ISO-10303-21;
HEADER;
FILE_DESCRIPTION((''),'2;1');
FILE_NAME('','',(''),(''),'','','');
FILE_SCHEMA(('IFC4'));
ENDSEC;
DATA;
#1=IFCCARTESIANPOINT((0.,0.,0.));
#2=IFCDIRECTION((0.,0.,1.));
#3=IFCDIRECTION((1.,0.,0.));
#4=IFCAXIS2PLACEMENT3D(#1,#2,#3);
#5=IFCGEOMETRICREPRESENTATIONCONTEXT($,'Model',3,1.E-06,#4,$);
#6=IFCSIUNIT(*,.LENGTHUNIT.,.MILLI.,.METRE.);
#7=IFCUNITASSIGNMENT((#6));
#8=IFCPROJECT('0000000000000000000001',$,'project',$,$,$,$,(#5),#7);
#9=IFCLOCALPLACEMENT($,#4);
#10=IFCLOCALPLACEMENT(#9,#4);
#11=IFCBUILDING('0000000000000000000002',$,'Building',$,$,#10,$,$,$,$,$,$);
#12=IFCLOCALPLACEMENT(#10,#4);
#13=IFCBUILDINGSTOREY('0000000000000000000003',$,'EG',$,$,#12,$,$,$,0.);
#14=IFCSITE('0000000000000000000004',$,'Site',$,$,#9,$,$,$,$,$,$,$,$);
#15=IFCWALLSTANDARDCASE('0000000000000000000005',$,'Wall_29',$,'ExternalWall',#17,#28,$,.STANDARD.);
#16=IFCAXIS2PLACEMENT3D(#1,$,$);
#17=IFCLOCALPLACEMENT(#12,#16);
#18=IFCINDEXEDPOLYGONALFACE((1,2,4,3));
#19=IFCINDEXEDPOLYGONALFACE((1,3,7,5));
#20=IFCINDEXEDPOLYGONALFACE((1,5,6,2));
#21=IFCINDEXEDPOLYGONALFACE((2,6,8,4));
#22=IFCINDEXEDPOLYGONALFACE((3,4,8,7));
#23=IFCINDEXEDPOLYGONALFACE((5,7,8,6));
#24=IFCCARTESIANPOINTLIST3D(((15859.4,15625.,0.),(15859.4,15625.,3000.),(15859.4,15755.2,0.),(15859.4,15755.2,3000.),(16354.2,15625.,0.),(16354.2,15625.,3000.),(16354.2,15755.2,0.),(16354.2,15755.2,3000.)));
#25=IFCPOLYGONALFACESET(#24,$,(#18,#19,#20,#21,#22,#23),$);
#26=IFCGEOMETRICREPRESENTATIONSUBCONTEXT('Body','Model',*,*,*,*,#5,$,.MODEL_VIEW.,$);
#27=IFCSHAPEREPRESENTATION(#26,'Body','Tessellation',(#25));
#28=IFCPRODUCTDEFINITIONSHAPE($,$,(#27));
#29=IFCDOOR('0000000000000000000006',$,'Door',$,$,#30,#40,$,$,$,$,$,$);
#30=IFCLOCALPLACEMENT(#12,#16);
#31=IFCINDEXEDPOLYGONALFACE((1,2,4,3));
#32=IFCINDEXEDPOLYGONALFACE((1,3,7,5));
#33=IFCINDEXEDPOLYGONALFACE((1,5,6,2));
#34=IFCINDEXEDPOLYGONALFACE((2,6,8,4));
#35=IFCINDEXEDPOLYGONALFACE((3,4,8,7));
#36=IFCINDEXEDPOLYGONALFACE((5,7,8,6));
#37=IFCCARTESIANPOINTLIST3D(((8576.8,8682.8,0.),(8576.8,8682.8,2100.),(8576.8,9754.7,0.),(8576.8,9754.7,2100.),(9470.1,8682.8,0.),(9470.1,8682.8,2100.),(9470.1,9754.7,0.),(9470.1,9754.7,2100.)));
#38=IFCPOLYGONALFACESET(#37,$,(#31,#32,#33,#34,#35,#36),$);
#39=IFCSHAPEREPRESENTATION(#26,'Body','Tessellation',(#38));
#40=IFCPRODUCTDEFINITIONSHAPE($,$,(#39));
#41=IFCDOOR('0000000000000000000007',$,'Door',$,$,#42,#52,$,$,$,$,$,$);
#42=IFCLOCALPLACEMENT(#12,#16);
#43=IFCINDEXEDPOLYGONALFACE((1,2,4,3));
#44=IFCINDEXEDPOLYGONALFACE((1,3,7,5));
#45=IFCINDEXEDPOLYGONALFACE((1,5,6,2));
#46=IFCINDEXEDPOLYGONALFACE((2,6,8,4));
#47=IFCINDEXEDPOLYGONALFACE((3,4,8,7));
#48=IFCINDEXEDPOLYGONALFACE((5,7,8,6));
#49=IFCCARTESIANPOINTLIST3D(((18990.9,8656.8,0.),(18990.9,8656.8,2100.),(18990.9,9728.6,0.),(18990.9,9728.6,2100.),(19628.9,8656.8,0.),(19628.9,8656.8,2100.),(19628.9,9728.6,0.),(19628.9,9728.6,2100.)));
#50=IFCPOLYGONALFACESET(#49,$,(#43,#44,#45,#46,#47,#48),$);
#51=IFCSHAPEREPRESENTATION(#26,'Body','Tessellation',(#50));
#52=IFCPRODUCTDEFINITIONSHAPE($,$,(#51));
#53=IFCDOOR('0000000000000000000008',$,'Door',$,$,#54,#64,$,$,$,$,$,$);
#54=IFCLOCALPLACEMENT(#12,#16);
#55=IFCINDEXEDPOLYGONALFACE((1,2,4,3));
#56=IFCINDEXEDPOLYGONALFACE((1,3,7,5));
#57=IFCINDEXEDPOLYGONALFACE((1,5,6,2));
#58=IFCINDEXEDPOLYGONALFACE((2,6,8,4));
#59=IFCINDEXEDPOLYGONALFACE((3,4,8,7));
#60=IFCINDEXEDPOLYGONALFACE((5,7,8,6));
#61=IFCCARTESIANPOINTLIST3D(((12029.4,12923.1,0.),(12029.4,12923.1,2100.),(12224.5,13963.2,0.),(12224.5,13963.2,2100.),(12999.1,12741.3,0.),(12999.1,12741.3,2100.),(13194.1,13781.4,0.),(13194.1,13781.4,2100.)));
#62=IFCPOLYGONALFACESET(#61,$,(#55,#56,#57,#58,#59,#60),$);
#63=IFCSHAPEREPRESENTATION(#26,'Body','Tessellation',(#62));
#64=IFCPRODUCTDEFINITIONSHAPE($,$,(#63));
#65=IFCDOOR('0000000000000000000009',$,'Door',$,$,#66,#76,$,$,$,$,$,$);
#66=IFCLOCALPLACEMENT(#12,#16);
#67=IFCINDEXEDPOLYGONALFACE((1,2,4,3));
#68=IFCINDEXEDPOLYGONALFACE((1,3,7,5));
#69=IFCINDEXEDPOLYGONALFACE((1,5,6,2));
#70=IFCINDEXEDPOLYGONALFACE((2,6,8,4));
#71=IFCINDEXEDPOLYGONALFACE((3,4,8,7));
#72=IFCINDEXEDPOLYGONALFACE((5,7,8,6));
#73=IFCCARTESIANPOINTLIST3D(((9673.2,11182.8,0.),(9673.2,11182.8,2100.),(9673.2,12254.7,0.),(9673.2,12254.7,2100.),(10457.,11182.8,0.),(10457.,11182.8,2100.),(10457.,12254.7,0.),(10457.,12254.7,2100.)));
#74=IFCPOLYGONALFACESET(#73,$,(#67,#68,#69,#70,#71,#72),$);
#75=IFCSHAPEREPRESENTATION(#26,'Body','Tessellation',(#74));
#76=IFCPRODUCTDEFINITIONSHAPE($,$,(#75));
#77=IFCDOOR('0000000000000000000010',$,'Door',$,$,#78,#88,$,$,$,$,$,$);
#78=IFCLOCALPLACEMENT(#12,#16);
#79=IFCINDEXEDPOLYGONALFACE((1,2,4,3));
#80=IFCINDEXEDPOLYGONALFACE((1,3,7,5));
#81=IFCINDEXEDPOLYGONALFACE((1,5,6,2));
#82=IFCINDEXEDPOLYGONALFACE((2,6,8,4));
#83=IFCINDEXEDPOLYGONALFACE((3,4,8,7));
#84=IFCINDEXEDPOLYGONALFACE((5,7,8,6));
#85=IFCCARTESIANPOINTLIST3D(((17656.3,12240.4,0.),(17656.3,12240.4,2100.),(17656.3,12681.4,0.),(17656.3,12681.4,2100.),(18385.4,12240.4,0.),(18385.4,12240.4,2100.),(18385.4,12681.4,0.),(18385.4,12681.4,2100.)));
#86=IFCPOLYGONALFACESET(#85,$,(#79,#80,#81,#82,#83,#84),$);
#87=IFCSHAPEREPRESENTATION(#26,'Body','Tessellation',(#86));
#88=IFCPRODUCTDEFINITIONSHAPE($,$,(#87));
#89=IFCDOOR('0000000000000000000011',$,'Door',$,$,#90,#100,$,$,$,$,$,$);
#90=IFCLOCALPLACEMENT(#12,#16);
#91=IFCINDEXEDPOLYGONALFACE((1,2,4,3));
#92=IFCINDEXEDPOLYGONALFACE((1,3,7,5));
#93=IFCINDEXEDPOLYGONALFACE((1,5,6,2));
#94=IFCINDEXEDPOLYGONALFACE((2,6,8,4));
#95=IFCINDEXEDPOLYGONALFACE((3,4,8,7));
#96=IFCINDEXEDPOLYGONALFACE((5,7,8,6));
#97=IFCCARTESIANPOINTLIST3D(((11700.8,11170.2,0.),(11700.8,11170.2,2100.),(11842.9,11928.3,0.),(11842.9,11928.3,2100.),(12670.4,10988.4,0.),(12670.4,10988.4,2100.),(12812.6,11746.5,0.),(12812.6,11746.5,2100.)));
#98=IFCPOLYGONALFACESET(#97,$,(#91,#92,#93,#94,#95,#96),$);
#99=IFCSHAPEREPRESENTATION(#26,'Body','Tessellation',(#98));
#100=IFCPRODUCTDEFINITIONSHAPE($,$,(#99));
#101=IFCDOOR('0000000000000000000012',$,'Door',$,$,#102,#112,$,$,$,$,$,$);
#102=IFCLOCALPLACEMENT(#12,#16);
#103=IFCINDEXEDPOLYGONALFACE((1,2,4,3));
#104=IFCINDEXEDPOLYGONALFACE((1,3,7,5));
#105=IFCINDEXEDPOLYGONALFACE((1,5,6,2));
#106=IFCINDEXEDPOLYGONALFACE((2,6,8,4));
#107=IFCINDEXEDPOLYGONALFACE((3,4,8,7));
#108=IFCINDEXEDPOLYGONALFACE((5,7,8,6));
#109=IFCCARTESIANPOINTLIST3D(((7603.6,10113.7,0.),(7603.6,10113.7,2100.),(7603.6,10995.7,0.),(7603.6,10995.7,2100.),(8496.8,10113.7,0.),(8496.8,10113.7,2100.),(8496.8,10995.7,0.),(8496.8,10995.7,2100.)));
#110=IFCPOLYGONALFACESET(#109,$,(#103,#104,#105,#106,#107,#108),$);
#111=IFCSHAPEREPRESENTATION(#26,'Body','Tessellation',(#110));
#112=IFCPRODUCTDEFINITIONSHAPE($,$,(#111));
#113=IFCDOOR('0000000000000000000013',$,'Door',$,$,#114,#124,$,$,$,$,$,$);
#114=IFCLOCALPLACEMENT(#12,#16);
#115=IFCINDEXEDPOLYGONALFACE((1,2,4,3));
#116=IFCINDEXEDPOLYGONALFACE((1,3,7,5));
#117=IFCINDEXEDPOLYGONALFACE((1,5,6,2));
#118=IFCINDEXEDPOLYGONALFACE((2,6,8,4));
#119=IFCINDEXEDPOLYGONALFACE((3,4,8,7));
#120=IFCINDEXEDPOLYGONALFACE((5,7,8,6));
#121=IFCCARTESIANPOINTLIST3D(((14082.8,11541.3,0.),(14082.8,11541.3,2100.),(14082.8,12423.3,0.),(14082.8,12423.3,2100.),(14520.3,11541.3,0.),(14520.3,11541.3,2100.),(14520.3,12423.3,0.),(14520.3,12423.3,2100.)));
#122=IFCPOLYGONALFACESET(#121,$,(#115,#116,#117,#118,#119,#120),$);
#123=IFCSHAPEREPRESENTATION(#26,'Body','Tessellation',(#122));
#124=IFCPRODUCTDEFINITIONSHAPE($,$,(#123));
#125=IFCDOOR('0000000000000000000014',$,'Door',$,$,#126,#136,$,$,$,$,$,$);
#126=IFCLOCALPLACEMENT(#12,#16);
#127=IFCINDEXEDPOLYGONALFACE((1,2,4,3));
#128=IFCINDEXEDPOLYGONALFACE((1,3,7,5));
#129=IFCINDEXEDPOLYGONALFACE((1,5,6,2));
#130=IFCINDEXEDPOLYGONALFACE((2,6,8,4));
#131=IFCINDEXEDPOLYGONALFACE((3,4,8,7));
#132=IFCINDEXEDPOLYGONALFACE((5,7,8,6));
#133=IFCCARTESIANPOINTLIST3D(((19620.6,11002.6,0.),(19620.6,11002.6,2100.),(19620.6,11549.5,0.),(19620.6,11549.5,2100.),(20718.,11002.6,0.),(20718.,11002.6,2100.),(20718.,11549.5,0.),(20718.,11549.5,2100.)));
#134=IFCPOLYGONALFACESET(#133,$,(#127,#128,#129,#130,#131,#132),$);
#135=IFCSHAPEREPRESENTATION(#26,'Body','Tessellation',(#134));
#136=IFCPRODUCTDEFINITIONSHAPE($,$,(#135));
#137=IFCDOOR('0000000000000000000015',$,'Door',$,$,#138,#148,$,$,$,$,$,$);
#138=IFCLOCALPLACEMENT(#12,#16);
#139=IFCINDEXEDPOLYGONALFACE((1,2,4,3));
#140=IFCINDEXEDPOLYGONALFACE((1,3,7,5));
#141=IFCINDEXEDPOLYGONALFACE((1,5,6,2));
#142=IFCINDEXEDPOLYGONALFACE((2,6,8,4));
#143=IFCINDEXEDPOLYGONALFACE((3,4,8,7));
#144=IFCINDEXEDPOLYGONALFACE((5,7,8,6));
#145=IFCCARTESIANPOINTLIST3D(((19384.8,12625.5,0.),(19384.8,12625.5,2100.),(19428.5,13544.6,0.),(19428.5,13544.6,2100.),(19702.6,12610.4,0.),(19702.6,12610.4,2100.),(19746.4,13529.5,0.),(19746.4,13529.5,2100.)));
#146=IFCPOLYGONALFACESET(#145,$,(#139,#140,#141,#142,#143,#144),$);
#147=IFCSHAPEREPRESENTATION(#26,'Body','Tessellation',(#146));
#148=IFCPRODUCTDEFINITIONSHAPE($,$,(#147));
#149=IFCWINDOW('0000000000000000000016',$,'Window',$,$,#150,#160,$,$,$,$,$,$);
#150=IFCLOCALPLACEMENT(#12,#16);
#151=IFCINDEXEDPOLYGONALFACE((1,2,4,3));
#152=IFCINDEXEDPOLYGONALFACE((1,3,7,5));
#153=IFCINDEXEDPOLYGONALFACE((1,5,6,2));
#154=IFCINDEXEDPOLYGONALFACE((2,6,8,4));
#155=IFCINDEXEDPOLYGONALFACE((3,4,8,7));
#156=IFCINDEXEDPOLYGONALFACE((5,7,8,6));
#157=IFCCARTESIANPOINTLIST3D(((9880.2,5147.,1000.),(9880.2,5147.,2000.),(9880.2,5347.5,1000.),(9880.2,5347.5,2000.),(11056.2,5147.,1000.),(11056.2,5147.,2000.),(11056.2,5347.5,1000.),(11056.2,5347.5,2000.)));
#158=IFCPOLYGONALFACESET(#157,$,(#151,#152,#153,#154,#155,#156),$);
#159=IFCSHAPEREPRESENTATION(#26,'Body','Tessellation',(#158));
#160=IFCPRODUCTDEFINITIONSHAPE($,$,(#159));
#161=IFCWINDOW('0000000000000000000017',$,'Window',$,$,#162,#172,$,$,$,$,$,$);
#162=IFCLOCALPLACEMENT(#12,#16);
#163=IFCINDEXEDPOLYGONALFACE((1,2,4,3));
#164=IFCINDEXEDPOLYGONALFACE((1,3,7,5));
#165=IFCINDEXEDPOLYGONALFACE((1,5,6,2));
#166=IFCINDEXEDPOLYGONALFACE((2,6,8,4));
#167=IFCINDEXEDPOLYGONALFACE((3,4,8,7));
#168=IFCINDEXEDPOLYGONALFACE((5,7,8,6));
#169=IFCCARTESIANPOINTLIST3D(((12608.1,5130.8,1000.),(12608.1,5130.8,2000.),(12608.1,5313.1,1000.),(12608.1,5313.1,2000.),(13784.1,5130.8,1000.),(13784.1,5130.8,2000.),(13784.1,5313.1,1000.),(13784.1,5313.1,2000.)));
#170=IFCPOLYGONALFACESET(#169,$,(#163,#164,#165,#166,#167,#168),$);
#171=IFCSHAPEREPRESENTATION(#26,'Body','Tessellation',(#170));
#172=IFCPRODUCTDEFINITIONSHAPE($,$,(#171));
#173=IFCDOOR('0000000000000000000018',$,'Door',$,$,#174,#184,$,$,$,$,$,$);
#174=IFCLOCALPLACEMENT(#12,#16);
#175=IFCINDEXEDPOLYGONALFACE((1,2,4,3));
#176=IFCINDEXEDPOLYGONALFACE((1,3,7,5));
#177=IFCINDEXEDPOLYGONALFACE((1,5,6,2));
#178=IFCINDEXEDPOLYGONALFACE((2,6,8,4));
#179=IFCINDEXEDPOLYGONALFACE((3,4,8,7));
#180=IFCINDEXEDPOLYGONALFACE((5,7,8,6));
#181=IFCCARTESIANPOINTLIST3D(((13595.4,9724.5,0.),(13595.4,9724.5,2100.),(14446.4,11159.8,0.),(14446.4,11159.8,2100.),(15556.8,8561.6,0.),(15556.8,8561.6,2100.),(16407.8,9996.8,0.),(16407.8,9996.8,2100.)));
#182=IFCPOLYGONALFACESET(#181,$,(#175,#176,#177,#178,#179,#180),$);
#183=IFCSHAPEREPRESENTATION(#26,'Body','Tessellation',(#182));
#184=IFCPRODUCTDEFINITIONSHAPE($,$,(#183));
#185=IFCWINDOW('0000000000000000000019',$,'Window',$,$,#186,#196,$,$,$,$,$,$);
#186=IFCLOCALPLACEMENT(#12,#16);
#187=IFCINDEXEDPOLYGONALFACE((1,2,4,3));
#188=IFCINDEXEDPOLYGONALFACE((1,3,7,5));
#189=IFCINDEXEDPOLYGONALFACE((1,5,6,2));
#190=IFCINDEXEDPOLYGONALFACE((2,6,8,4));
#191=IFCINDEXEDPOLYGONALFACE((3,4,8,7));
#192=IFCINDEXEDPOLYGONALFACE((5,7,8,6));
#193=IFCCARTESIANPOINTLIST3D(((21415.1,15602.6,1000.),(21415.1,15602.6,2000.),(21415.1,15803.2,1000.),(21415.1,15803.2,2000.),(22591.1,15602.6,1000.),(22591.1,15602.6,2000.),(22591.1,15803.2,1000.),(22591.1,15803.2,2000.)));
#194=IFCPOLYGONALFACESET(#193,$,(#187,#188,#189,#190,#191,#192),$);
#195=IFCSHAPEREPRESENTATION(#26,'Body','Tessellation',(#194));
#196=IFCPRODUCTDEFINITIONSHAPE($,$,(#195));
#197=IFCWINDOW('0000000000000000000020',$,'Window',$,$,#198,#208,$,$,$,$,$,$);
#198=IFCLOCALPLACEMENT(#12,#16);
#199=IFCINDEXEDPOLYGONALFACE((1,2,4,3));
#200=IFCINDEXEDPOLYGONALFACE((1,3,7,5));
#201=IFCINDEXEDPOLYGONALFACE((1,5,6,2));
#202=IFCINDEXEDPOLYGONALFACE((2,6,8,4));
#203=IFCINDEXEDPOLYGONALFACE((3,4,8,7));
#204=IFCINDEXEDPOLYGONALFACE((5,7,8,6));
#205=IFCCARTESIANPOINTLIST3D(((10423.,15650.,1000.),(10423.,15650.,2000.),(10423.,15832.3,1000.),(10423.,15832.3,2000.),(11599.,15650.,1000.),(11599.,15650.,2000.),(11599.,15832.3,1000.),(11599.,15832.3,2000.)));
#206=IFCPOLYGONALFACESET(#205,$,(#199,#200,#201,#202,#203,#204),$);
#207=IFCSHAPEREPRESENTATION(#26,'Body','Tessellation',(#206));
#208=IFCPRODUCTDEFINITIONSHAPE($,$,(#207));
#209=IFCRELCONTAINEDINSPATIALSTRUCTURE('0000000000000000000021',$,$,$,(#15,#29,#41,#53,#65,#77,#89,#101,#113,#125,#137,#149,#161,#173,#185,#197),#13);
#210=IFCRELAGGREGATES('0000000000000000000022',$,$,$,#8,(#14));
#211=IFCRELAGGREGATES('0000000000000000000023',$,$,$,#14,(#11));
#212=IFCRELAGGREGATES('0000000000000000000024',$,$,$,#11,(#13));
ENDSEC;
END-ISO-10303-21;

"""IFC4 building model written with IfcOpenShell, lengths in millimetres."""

from ifc_helpers import new_model, si_unit, frame, origin_with_axes, place, context, subcontext, project, spatial, rectangle, extrude, element, save


model = new_model("IFC4")

# Units and contexts
model_context = context("Model", 3, precision=1e-06, world=origin_with_axes())
body_context = subcontext(model_context, "Body", "Model", "MODEL_VIEW")
ifc_project = project(units=[si_unit("LENGTHUNIT", "METRE", prefix="MILLI")], contexts=[model_context])

# Site, building, storey
site_placement = place(None, origin_with_axes())
site = spatial("IfcSite", under=ifc_project, at=site_placement, Name="Site")
building_placement = place(site_placement, origin_with_axes())
building = spatial("IfcBuilding", under=site, at=building_placement, Name="Building")
storey_placement = place(building_placement, origin_with_axes())
storey = spatial("IfcBuildingStorey", under=building, at=storey_placement, Name="EG", Elevation=0.0)

# Wall
wall_placement = place(storey_placement, origin_with_axes())
element("IfcWallStandardCase", 1, at=wall_placement, inside=storey, Name="Wall_29", ObjectType="ExternalWall", PredefinedType="STANDARD", context=body_context, shape_type="SweptSolid", body=[
    extrude(rectangle(XDim=494.8, YDim=130.2), frame((16106.8, 15690.1, 0.0), z_axis=(0.0, 0.0, 1.0), x_axis=(1.0, 0.0, 0.0)), (0.0, 0.0, 1.0), 3000.0),
])

# Doors
door_1_placement = place(storey_placement, origin_with_axes())
element("IfcDoor", 2, at=door_1_placement, inside=storey, Name="Door", context=body_context, shape_type="SweptSolid", body=[
    extrude(rectangle(XDim=1071.9, YDim=893.2), frame((9023.4, 9218.8, 0.0), z_axis=(0.0, 0.0, 1.0), x_axis=(0.0, 1.0, 0.0)), (0.0, 0.0, 1.0), 2100.0),
])
door_2_placement = place(storey_placement, origin_with_axes())
element("IfcDoor", 3, at=door_2_placement, inside=storey, Name="Door", context=body_context, shape_type="SweptSolid", body=[
    extrude(rectangle(XDim=1071.9, YDim=638.0), frame((19309.9, 9192.7, 0.0), z_axis=(0.0, 0.0, 1.0), x_axis=(0.0, 1.0, 0.0)), (0.0, 0.0, 1.0), 2100.0),
])
door_3_placement = place(storey_placement, origin_with_axes())
element("IfcDoor", 4, at=door_3_placement, inside=storey, Name="Door", context=body_context, shape_type="SweptSolid", body=[
    extrude(rectangle(XDim=1058.2, YDim=986.6), frame((12611.8, 13352.3, 0.0), z_axis=(0.0, 0.0, 1.0), x_axis=(0.184288, 0.982872, 0.0)), (0.0, 0.0, 1.0), 2100.0),
])
door_4_placement = place(storey_placement, origin_with_axes())
element("IfcDoor", 5, at=door_4_placement, inside=storey, Name="Door", context=body_context, shape_type="SweptSolid", body=[
    extrude(rectangle(XDim=1071.9, YDim=783.9), frame((10065.1, 11718.8, 0.0), z_axis=(0.0, 0.0, 1.0), x_axis=(0.0, -1.0, 0.0)), (0.0, 0.0, 1.0), 2100.0),
])
door_5_placement = place(storey_placement, origin_with_axes())
element("IfcDoor", 6, at=door_5_placement, inside=storey, Name="Door", context=body_context, shape_type="SweptSolid", body=[
    extrude(rectangle(XDim=441.0, YDim=729.2), frame((18020.8, 12460.9, 0.0), z_axis=(0.0, 0.0, 1.0), x_axis=(0.0, 1.0, 0.0)), (0.0, 0.0, 1.0), 2100.0),
])
door_6_placement = place(storey_placement, origin_with_axes())
element("IfcDoor", 7, at=door_6_placement, inside=storey, Name="Door", context=body_context, shape_type="SweptSolid", body=[
    extrude(rectangle(XDim=771.3, YDim=986.6), frame((12256.7, 11458.4, 0.0), z_axis=(0.0, 0.0, 1.0), x_axis=(0.184288, 0.982872, 0.0)), (0.0, 0.0, 1.0), 2100.0),
])
door_7_placement = place(storey_placement, origin_with_axes())
element("IfcDoor", 8, at=door_7_placement, inside=storey, Name="Door", context=body_context, shape_type="SweptSolid", body=[
    extrude(rectangle(XDim=882.0, YDim=893.2), frame((8050.2, 10554.7, 0.0), z_axis=(0.0, 0.0, 1.0), x_axis=(0.0, 1.0, 0.0)), (0.0, 0.0, 1.0), 2100.0),
])
door_8_placement = place(storey_placement, origin_with_axes())
element("IfcDoor", 9, at=door_8_placement, inside=storey, Name="Door", context=body_context, shape_type="SweptSolid", body=[
    extrude(rectangle(XDim=882.0, YDim=437.5), frame((14301.5, 11982.3, 0.0), z_axis=(0.0, 0.0, 1.0), x_axis=(0.0, 1.0, 0.0)), (0.0, 0.0, 1.0), 2100.0),
])
door_9_placement = place(storey_placement, origin_with_axes())
element("IfcDoor", 10, at=door_9_placement, inside=storey, Name="Door", context=body_context, shape_type="SweptSolid", body=[
    extrude(rectangle(XDim=1097.4, YDim=546.9), frame((20169.3, 11276.0, 0.0), z_axis=(0.0, 0.0, 1.0), x_axis=(1.0, 0.0, 0.0)), (0.0, 0.0, 1.0), 2100.0),
])
door_10_placement = place(storey_placement, origin_with_axes())
element("IfcDoor", 11, at=door_10_placement, inside=storey, Name="Door", context=body_context, shape_type="SweptSolid", body=[
    extrude(rectangle(XDim=920.1, YDim=318.2), frame((19565.6, 13077.5, 0.0), z_axis=(0.0, 0.0, 1.0), x_axis=(-0.047565, -0.998868, 0.0)), (0.0, 0.0, 1.0), 2100.0),
])

# Windows
window_1_placement = place(storey_placement, origin_with_axes())
element("IfcWindow", 12, at=window_1_placement, inside=storey, Name="Window", context=body_context, shape_type="SweptSolid", body=[
    extrude(rectangle(XDim=1176.0, YDim=200.5), frame((10468.2, 5247.3, 1000.0), z_axis=(0.0, 0.0, 1.0), x_axis=(-1.0, 0.0, 0.0)), (0.0, 0.0, 1.0), 1000.0),
])
window_2_placement = place(storey_placement, origin_with_axes())
element("IfcWindow", 13, at=window_2_placement, inside=storey, Name="Window", context=body_context, shape_type="SweptSolid", body=[
    extrude(rectangle(XDim=1176.0, YDim=182.3), frame((13196.1, 5222.0, 1000.0), z_axis=(0.0, 0.0, 1.0), x_axis=(1.0, 0.0, 0.0)), (0.0, 0.0, 1.0), 1000.0),
])

# Door
door_11_placement = place(storey_placement, origin_with_axes())
element("IfcDoor", 14, at=door_11_placement, inside=storey, Name="Door", context=body_context, shape_type="SweptSolid", body=[
    extrude(rectangle(XDim=1668.6, YDim=2280.3), frame((15001.6, 9860.7, 0.0), z_axis=(0.0, 0.0, 1.0), x_axis=(-0.510011, -0.860168, 0.0)), (0.0, 0.0, 1.0), 2100.0),
])

# Windows
window_3_placement = place(storey_placement, origin_with_axes())
element("IfcWindow", 15, at=window_3_placement, inside=storey, Name="Window", context=body_context, shape_type="SweptSolid", body=[
    extrude(rectangle(XDim=1176.0, YDim=200.5), frame((22003.1, 15702.9, 1000.0), z_axis=(0.0, 0.0, 1.0), x_axis=(1.0, 0.0, 0.0)), (0.0, 0.0, 1.0), 1000.0),
])
window_4_placement = place(storey_placement, origin_with_axes())
element("IfcWindow", 16, at=window_4_placement, inside=storey, Name="Window", context=body_context, shape_type="SweptSolid", body=[
    extrude(rectangle(XDim=1176.0, YDim=182.3), frame((11011.0, 15741.2, 1000.0), z_axis=(0.0, 0.0, 1.0), x_axis=(1.0, 0.0, 0.0)), (0.0, 0.0, 1.0), 1000.0),
])

save(model, "model.ifc")
